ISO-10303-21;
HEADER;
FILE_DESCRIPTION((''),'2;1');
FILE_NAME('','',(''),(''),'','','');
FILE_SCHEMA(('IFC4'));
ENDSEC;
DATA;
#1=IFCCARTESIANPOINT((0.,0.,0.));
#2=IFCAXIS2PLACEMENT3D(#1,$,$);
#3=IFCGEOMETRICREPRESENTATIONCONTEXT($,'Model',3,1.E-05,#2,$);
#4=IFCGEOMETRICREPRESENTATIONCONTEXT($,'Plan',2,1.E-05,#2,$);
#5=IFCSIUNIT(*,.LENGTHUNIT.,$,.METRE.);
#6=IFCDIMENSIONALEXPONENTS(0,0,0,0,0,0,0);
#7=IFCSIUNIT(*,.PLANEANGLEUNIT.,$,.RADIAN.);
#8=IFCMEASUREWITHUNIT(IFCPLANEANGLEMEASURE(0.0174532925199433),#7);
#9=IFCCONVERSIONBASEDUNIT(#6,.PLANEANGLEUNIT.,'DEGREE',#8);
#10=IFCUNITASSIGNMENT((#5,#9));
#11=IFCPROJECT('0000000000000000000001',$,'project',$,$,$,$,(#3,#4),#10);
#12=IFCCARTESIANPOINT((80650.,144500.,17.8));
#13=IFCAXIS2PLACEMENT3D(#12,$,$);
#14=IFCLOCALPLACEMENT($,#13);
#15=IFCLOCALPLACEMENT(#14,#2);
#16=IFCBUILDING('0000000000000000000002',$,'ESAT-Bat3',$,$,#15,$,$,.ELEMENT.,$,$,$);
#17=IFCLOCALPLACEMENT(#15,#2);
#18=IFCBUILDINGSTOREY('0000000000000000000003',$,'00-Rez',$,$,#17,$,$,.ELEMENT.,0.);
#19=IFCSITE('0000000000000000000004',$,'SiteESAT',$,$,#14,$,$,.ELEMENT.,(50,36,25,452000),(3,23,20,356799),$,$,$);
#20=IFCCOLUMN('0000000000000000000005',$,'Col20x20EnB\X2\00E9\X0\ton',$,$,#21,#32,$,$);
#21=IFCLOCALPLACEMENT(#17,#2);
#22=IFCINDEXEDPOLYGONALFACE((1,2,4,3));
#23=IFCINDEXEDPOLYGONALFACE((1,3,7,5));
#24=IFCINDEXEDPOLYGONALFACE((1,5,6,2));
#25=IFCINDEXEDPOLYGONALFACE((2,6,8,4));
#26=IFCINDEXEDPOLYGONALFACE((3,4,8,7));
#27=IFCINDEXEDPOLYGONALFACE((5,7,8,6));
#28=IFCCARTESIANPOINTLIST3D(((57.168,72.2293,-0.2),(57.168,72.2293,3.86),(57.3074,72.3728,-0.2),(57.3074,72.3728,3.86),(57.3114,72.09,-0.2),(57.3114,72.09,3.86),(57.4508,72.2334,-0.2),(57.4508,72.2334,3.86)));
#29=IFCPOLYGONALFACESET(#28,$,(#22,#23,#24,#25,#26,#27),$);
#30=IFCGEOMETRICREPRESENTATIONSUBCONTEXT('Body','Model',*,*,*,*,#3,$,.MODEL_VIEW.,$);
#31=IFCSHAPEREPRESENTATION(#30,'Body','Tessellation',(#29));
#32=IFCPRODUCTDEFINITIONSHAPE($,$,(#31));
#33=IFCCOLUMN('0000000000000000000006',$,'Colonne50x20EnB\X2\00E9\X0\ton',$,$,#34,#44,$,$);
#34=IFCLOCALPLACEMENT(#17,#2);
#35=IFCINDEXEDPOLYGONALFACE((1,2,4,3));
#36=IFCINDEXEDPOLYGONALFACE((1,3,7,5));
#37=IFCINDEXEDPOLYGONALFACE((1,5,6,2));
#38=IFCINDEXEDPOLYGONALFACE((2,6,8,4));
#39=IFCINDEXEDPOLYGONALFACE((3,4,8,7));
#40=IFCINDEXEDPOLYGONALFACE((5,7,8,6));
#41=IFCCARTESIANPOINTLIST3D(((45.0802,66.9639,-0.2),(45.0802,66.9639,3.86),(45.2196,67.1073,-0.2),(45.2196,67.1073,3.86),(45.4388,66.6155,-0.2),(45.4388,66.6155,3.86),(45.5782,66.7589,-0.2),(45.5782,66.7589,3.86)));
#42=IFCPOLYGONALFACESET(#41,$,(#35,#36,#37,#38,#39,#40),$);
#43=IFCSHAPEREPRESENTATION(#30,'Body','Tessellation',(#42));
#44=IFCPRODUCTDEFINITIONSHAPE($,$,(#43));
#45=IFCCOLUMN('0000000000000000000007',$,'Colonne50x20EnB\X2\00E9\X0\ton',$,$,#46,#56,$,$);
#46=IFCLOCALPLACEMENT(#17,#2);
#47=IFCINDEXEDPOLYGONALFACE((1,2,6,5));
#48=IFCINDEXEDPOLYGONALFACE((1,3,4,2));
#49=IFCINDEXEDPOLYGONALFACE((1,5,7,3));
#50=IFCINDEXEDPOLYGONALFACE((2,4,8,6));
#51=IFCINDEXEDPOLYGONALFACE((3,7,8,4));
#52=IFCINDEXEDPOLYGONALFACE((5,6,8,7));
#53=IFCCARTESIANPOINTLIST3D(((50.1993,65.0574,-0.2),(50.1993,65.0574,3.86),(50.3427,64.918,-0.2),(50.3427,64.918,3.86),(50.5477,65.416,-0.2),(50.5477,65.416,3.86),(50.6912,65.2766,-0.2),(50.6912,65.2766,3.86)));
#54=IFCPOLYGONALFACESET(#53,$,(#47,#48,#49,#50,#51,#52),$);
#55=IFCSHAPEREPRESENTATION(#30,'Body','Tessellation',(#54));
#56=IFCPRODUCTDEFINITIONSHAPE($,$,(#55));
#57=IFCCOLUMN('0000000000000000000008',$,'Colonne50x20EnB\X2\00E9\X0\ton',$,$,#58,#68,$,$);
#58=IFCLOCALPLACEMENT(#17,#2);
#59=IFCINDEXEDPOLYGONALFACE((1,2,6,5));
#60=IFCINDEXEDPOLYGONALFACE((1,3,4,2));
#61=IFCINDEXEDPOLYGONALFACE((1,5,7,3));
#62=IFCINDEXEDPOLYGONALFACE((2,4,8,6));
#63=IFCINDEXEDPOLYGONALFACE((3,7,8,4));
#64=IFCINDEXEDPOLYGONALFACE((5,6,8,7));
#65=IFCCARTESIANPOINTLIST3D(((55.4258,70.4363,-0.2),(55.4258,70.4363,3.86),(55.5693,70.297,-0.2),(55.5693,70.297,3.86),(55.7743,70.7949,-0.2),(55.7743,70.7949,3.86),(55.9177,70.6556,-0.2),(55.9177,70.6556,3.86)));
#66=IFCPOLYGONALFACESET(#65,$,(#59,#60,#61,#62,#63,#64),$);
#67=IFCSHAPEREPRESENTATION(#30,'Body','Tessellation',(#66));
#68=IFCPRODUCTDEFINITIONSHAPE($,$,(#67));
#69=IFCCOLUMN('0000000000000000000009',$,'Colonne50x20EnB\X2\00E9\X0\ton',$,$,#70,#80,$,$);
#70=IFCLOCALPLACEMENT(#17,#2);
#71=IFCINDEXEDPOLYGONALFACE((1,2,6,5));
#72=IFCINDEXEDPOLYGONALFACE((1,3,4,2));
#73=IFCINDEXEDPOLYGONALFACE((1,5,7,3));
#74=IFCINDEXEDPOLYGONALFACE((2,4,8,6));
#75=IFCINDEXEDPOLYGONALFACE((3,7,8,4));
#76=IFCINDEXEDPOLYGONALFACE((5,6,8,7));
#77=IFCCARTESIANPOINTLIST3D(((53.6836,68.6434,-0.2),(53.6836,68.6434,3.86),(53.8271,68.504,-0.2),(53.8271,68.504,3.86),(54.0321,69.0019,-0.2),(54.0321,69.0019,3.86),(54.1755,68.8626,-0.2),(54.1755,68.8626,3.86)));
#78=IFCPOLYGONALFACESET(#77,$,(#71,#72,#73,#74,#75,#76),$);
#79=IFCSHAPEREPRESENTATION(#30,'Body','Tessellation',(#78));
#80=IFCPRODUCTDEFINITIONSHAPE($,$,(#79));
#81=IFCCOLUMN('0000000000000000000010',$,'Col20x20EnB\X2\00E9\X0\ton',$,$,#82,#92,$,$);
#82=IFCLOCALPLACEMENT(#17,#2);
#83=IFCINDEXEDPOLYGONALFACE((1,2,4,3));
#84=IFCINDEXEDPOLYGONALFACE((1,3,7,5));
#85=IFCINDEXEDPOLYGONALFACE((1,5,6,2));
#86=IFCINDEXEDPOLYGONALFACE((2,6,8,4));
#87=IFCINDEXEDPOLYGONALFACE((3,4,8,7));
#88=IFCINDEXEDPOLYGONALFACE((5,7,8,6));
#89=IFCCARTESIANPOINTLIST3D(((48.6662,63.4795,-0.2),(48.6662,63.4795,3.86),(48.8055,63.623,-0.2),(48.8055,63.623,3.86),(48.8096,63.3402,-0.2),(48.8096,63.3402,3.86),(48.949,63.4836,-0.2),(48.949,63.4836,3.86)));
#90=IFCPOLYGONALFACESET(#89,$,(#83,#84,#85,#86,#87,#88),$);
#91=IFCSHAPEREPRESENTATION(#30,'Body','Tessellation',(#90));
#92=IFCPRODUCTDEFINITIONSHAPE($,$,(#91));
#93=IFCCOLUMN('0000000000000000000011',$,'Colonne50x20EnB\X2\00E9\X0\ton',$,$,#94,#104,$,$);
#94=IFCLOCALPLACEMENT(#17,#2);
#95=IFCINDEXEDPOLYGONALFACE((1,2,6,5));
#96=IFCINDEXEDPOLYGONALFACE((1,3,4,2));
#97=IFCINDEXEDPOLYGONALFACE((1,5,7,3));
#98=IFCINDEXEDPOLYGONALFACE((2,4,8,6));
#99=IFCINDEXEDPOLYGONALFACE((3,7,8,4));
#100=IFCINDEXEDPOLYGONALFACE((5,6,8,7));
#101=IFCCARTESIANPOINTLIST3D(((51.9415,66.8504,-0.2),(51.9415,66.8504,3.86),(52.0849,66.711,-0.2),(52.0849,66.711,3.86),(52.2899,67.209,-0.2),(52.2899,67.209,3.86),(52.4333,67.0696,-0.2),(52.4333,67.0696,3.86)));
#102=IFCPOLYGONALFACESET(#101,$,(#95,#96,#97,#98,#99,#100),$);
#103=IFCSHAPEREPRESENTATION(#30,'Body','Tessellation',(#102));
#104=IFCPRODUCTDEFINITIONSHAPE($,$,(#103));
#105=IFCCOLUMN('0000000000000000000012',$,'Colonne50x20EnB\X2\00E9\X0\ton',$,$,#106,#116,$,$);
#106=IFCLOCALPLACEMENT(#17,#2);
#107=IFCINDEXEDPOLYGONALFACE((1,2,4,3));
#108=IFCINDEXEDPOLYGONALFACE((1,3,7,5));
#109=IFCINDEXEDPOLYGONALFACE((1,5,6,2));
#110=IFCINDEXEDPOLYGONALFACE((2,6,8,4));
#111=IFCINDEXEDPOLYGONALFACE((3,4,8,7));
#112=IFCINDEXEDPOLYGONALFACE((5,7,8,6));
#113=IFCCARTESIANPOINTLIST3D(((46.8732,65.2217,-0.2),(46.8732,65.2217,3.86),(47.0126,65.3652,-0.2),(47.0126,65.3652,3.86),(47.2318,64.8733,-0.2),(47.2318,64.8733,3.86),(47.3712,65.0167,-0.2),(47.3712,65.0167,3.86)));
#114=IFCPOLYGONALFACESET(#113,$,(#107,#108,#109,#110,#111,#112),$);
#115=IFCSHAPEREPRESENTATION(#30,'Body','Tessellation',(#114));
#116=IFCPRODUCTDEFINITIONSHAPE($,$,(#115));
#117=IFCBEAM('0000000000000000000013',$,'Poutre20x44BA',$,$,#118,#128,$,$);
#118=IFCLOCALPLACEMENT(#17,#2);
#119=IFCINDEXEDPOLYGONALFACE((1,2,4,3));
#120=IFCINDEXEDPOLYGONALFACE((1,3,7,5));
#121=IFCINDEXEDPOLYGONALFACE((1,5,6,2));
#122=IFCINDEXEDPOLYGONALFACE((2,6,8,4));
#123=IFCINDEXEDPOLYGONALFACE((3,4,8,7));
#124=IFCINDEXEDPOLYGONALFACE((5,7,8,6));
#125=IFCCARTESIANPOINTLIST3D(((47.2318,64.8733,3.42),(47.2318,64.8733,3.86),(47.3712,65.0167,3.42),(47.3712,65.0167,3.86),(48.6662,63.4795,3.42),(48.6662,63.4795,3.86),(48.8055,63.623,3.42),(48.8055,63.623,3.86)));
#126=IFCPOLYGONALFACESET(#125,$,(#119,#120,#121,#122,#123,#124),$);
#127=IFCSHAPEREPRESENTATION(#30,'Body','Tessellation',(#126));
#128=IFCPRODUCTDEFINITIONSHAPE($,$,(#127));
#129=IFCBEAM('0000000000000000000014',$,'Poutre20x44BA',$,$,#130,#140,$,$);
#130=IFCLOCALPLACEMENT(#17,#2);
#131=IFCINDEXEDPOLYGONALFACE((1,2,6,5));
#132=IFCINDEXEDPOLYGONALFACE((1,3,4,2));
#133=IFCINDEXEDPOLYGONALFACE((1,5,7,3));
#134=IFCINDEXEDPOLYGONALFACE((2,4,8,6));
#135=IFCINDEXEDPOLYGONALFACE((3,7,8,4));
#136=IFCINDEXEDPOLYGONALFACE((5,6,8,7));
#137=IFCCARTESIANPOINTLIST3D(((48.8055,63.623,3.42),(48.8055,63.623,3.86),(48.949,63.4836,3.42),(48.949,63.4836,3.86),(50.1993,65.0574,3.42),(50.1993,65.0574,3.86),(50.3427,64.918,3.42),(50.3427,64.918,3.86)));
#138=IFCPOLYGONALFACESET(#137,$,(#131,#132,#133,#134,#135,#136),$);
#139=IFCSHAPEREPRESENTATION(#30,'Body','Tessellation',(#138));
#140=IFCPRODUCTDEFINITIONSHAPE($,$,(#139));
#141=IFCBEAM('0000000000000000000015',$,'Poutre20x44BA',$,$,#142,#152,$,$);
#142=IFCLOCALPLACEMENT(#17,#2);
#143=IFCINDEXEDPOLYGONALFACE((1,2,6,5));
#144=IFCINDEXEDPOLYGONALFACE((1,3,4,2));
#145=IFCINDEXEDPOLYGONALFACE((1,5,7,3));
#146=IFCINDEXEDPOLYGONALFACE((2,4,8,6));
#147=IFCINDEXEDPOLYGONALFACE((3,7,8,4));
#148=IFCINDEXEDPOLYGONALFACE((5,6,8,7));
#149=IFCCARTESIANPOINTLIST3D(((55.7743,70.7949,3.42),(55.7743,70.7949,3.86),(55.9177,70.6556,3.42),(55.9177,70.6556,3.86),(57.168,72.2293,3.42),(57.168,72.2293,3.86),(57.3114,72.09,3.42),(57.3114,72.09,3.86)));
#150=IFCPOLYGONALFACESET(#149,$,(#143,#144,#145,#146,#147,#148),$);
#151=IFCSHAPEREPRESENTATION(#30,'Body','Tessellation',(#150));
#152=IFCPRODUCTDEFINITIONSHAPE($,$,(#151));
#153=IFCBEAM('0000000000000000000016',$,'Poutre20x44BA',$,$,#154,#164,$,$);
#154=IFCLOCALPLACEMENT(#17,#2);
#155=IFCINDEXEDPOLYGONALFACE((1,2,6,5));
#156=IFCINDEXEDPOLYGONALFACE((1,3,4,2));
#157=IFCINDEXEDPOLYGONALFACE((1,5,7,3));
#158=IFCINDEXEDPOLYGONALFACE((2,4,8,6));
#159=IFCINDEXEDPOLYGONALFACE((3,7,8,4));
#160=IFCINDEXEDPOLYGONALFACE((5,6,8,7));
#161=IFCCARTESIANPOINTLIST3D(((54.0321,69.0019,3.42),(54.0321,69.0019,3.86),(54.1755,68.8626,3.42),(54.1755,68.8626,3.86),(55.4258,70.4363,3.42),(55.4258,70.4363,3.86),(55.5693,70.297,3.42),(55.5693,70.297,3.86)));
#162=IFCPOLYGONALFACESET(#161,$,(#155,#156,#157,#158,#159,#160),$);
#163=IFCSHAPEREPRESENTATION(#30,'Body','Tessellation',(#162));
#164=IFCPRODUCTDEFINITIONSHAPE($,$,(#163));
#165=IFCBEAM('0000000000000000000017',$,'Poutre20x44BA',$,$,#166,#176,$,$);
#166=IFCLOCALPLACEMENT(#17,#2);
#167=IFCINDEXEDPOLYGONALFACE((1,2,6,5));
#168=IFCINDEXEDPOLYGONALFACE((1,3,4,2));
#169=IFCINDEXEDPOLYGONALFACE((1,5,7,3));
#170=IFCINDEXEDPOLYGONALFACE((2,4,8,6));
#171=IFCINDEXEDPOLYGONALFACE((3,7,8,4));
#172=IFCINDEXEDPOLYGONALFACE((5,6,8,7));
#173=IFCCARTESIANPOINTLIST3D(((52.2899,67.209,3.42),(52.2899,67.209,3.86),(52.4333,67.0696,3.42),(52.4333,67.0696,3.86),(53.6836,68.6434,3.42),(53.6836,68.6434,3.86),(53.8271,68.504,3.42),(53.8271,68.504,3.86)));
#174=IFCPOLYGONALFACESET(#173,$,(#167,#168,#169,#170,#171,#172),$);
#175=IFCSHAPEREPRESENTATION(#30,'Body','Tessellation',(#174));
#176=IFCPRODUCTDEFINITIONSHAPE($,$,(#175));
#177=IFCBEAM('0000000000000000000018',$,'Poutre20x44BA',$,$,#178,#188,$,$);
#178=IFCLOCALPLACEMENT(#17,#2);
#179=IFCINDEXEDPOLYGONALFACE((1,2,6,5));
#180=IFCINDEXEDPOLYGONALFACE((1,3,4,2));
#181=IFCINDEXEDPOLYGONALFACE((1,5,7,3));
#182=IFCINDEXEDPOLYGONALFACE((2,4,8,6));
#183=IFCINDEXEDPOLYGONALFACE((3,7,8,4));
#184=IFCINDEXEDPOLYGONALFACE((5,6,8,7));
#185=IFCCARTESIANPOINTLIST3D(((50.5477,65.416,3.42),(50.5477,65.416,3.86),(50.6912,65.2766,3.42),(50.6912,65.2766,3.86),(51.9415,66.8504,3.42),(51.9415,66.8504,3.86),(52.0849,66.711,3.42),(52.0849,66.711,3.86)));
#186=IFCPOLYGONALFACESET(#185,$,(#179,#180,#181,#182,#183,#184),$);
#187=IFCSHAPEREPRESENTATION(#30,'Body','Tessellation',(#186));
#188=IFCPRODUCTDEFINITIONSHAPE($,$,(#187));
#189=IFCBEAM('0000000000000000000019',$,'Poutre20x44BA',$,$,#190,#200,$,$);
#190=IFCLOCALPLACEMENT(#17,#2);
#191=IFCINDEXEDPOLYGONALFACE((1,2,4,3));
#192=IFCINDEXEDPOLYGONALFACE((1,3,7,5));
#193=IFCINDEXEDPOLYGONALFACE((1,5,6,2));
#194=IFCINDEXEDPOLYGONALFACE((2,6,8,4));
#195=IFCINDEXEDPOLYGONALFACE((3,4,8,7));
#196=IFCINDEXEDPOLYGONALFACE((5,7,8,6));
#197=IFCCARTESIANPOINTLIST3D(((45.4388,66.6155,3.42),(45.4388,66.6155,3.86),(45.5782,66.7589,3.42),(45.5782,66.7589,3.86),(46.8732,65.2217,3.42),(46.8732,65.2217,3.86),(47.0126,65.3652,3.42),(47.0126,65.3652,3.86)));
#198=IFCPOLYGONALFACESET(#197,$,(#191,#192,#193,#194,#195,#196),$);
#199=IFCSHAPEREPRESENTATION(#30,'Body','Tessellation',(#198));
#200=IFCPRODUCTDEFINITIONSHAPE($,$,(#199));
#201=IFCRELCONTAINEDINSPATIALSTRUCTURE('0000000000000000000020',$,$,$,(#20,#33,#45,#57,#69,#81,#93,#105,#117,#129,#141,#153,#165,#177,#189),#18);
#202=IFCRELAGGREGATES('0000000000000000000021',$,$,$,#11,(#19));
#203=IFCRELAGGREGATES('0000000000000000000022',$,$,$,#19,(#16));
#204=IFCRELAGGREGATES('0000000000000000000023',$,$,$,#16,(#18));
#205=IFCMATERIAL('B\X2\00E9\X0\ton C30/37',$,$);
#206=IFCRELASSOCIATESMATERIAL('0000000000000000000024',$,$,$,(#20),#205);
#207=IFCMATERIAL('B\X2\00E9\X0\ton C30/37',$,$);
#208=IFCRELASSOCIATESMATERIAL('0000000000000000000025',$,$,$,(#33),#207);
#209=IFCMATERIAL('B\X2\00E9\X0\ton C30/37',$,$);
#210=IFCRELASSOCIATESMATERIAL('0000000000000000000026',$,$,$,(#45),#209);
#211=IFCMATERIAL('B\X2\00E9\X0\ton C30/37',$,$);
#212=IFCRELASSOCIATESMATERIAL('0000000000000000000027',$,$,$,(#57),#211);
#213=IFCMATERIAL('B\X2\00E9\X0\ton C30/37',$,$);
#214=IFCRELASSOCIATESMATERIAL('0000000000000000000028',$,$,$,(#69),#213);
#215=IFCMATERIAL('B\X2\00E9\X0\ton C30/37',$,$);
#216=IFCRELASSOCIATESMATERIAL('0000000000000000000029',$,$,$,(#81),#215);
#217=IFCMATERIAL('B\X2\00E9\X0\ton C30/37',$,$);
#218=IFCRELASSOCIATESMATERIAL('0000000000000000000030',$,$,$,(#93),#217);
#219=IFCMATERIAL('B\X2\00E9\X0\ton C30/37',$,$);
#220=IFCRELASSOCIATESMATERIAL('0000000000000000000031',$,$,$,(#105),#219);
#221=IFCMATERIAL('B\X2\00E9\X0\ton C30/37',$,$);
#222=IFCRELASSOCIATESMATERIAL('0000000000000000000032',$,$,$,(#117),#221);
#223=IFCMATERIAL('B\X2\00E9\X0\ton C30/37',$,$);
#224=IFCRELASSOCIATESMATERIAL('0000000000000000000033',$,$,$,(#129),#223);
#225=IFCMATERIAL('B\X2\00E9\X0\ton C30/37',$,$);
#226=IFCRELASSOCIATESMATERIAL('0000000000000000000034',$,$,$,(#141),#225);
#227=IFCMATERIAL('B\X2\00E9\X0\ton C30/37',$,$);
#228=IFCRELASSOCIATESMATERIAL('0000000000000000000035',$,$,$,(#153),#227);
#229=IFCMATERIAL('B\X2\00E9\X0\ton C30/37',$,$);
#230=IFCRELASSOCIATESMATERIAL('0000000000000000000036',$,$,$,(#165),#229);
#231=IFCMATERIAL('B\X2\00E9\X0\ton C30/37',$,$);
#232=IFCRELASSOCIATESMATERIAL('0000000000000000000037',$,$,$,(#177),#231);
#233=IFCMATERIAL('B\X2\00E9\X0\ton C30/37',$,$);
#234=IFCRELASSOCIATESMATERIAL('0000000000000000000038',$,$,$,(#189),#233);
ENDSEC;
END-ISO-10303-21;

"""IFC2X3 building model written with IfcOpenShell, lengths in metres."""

from ifc_helpers import new_model, entity, si_unit, converted_unit, frame, frame_2d, origin, origin_with_axes, place, context, subcontext, project, spatial, rectangle, extrude, material, element, save


model = new_model("IFC2X3")

# Units and contexts
model_context = context("Model", 3, precision=1e-05, world=origin())
plan_context = context("Plan", 2, precision=1e-05, world=origin())
body_context = subcontext(model_context, "Body", "Model", "MODEL_VIEW")
ifc_project = project(units=[si_unit("LENGTHUNIT", "METRE"), converted_unit("PLANEANGLEUNIT", "DEGREE", entity("IfcPlaneAngleMeasure", 0.0174532925199433), si_unit("PLANEANGLEUNIT", "RADIAN"), dimensions=[0, 0, 0, 0, 0, 0, 0])], contexts=[model_context, plan_context])

# Site, building, storey
site_placement = place(None, frame((80650.0, 144500.0, 17.8)))
site = spatial("IfcSite", under=ifc_project, at=site_placement, Name="SiteESAT", CompositionType="ELEMENT", RefLatitude=(50, 36, 25, 452000), RefLongitude=(3, 23, 20, 356799))
building_placement = place(site_placement, origin())
building = spatial("IfcBuilding", under=site, at=building_placement, Name="ESAT-Bat3", CompositionType="ELEMENT")
storey_placement = place(building_placement, origin())
storey = spatial("IfcBuildingStorey", under=building, at=storey_placement, Name="00-Rez", CompositionType="ELEMENT", Elevation=0.0)

# Columns
ifc_material_1 = material(Name="Béton C30/37")
column_1_placement = place(storey_placement, frame((57.3114, 72.09, -0.2)))
element("IfcColumn", 1, at=column_1_placement, inside=storey, material=ifc_material_1, Name="Col20x20EnBéton", context=body_context, shape_type="SweptSolid", body=[
    extrude(rectangle(XDim=0.2, YDim=0.2, at=frame_2d((-0.002, 0.1414), x_axis=(0.696872, 0.717196))), origin_with_axes(), (0.0, 0.0, 1.0), 4.06),
])
ifc_material_2 = material(Name="Béton C30/37")
column_2_placement = place(storey_placement, frame((45.5782, 66.7589, -0.2)))
element("IfcColumn", 2, at=column_2_placement, inside=storey, material=ifc_material_2, Name="Colonne50x20EnBéton", context=body_context, shape_type="SweptSolid", body=[
    extrude(rectangle(XDim=0.5, YDim=0.2, at=frame_2d((-0.249, 0.1025), x_axis=(-0.717196, 0.696872))), origin_with_axes(), (0.0, 0.0, 1.0), 4.06),
])
ifc_material_3 = material(Name="Béton C30/37")
column_3_placement = place(storey_placement, frame((50.3427, 64.918, -0.2)))
element("IfcColumn", 3, at=column_3_placement, inside=storey, material=ifc_material_3, Name="Colonne50x20EnBéton", context=body_context, shape_type="SweptSolid", body=[
    extrude(rectangle(XDim=0.5, YDim=0.2, at=frame_2d((0.1025, 0.249), x_axis=(0.696872, 0.717196))), origin_with_axes(), (0.0, 0.0, 1.0), 4.06),
])
ifc_material_4 = material(Name="Béton C30/37")
column_4_placement = place(storey_placement, frame((55.5693, 70.297, -0.2)))
element("IfcColumn", 4, at=column_4_placement, inside=storey, material=ifc_material_4, Name="Colonne50x20EnBéton", context=body_context, shape_type="SweptSolid", body=[
    extrude(rectangle(XDim=0.5, YDim=0.2, at=frame_2d((0.1025, 0.249), x_axis=(0.696872, 0.717196))), origin_with_axes(), (0.0, 0.0, 1.0), 4.06),
])
ifc_material_5 = material(Name="Béton C30/37")
column_5_placement = place(storey_placement, frame((53.8271, 68.504, -0.2)))
element("IfcColumn", 5, at=column_5_placement, inside=storey, material=ifc_material_5, Name="Colonne50x20EnBéton", context=body_context, shape_type="SweptSolid", body=[
    extrude(rectangle(XDim=0.5, YDim=0.2, at=frame_2d((0.1025, 0.249), x_axis=(0.696872, 0.717196))), origin_with_axes(), (0.0, 0.0, 1.0), 4.06),
])
ifc_material_6 = material(Name="Béton C30/37")
column_6_placement = place(storey_placement, frame((48.8096, 63.3402, -0.2)))
element("IfcColumn", 6, at=column_6_placement, inside=storey, material=ifc_material_6, Name="Col20x20EnBéton", context=body_context, shape_type="SweptSolid", body=[
    extrude(rectangle(XDim=0.2, YDim=0.2, at=frame_2d((-0.002, 0.1414), x_axis=(0.696872, 0.717196))), origin_with_axes(), (0.0, 0.0, 1.0), 4.06),
])
ifc_material_7 = material(Name="Béton C30/37")
column_7_placement = place(storey_placement, frame((52.0849, 66.711, -0.2)))
element("IfcColumn", 7, at=column_7_placement, inside=storey, material=ifc_material_7, Name="Colonne50x20EnBéton", context=body_context, shape_type="SweptSolid", body=[
    extrude(rectangle(XDim=0.5, YDim=0.2, at=frame_2d((0.1025, 0.249), x_axis=(0.696872, 0.717196))), origin_with_axes(), (0.0, 0.0, 1.0), 4.06),
])
ifc_material_8 = material(Name="Béton C30/37")
column_8_placement = place(storey_placement, frame((47.3712, 65.0167, -0.2)))
element("IfcColumn", 8, at=column_8_placement, inside=storey, material=ifc_material_8, Name="Colonne50x20EnBéton", context=body_context, shape_type="SweptSolid", body=[
    extrude(rectangle(XDim=0.5, YDim=0.2, at=frame_2d((-0.249, 0.1025), x_axis=(-0.717196, 0.696872))), origin_with_axes(), (0.0, 0.0, 1.0), 4.06),
])

# Beams
ifc_material_9 = material(Name="Béton C30/37")
beam_1_placement = place(storey_placement, frame((48.8055, 63.623, 3.42), z_axis=(0.0, 0.0, 1.0), x_axis=(-0.717196, 0.696872, 0.0)))
element("IfcBeam", 9, at=beam_1_placement, inside=storey, material=ifc_material_9, Name="Poutre20x44BA", context=body_context, shape_type="SweptSolid", body=[
    extrude(rectangle(XDim=0.2, YDim=0.44, at=frame_2d((0.1, 0.22), x_axis=(1.0, 0.0))), frame((0.0, 0.0, 0.0), z_axis=(1.0, 0.0, 0.0), x_axis=(0.0, 1.0, 0.0)), (0.0, 0.0, 1.0), 2.0),
])
ifc_material_10 = material(Name="Béton C30/37")
beam_2_placement = place(storey_placement, frame((48.949, 63.4836, 3.42), z_axis=(0.0, 0.0, 1.0), x_axis=(0.696872, 0.717196, 0.0)))
element("IfcBeam", 10, at=beam_2_placement, inside=storey, material=ifc_material_10, Name="Poutre20x44BA", context=body_context, shape_type="SweptSolid", body=[
    extrude(rectangle(XDim=0.2, YDim=0.44, at=frame_2d((0.1, 0.22), x_axis=(1.0, 0.0))), frame((0.0, 0.0, 0.0), z_axis=(1.0, 0.0, 0.0), x_axis=(0.0, 1.0, 0.0)), (0.0, 0.0, 1.0), 2.0),
])
ifc_material_11 = material(Name="Béton C30/37")
beam_3_placement = place(storey_placement, frame((55.9177, 70.6556, 3.42), z_axis=(0.0, 0.0, 1.0), x_axis=(0.696872, 0.717196, 0.0)))
element("IfcBeam", 11, at=beam_3_placement, inside=storey, material=ifc_material_11, Name="Poutre20x44BA", context=body_context, shape_type="SweptSolid", body=[
    extrude(rectangle(XDim=0.2, YDim=0.44, at=frame_2d((0.1, 0.22), x_axis=(1.0, 0.0))), frame((0.0, 0.0, 0.0), z_axis=(1.0, 0.0, 0.0), x_axis=(0.0, 1.0, 0.0)), (0.0, 0.0, 1.0), 2.0),
])
ifc_material_12 = material(Name="Béton C30/37")
beam_4_placement = place(storey_placement, frame((54.1755, 68.8626, 3.42), z_axis=(0.0, 0.0, 1.0), x_axis=(0.696872, 0.717196, 0.0)))
element("IfcBeam", 12, at=beam_4_placement, inside=storey, material=ifc_material_12, Name="Poutre20x44BA", context=body_context, shape_type="SweptSolid", body=[
    extrude(rectangle(XDim=0.2, YDim=0.44, at=frame_2d((0.1, 0.22), x_axis=(1.0, 0.0))), frame((0.0, 0.0, 0.0), z_axis=(1.0, 0.0, 0.0), x_axis=(0.0, 1.0, 0.0)), (0.0, 0.0, 1.0), 2.0),
])
ifc_material_13 = material(Name="Béton C30/37")
beam_5_placement = place(storey_placement, frame((52.4333, 67.0696, 3.42), z_axis=(0.0, 0.0, 1.0), x_axis=(0.696872, 0.717196, 0.0)))
element("IfcBeam", 13, at=beam_5_placement, inside=storey, material=ifc_material_13, Name="Poutre20x44BA", context=body_context, shape_type="SweptSolid", body=[
    extrude(rectangle(XDim=0.2, YDim=0.44, at=frame_2d((0.1, 0.22), x_axis=(1.0, 0.0))), frame((0.0, 0.0, 0.0), z_axis=(1.0, 0.0, 0.0), x_axis=(0.0, 1.0, 0.0)), (0.0, 0.0, 1.0), 2.0),
])
ifc_material_14 = material(Name="Béton C30/37")
beam_6_placement = place(storey_placement, frame((50.6912, 65.2766, 3.42), z_axis=(0.0, 0.0, 1.0), x_axis=(0.696872, 0.717196, 0.0)))
element("IfcBeam", 14, at=beam_6_placement, inside=storey, material=ifc_material_14, Name="Poutre20x44BA", context=body_context, shape_type="SweptSolid", body=[
    extrude(rectangle(XDim=0.2, YDim=0.44, at=frame_2d((0.1, 0.22), x_axis=(1.0, 0.0))), frame((0.0, 0.0, 0.0), z_axis=(1.0, 0.0, 0.0), x_axis=(0.0, 1.0, 0.0)), (0.0, 0.0, 1.0), 2.0),
])
ifc_material_15 = material(Name="Béton C30/37")
beam_7_placement = place(storey_placement, frame((47.0126, 65.3652, 3.42), z_axis=(0.0, 0.0, 1.0), x_axis=(-0.717196, 0.696872, 0.0)))
element("IfcBeam", 15, at=beam_7_placement, inside=storey, material=ifc_material_15, Name="Poutre20x44BA", context=body_context, shape_type="SweptSolid", body=[
    extrude(rectangle(XDim=0.2, YDim=0.44, at=frame_2d((0.1, 0.22), x_axis=(1.0, 0.0))), frame((0.0, 0.0, 0.0), z_axis=(1.0, 0.0, 0.0), x_axis=(0.0, 1.0, 0.0)), (0.0, 0.0, 1.0), 2.0),
])

save(model, "model.ifc")
